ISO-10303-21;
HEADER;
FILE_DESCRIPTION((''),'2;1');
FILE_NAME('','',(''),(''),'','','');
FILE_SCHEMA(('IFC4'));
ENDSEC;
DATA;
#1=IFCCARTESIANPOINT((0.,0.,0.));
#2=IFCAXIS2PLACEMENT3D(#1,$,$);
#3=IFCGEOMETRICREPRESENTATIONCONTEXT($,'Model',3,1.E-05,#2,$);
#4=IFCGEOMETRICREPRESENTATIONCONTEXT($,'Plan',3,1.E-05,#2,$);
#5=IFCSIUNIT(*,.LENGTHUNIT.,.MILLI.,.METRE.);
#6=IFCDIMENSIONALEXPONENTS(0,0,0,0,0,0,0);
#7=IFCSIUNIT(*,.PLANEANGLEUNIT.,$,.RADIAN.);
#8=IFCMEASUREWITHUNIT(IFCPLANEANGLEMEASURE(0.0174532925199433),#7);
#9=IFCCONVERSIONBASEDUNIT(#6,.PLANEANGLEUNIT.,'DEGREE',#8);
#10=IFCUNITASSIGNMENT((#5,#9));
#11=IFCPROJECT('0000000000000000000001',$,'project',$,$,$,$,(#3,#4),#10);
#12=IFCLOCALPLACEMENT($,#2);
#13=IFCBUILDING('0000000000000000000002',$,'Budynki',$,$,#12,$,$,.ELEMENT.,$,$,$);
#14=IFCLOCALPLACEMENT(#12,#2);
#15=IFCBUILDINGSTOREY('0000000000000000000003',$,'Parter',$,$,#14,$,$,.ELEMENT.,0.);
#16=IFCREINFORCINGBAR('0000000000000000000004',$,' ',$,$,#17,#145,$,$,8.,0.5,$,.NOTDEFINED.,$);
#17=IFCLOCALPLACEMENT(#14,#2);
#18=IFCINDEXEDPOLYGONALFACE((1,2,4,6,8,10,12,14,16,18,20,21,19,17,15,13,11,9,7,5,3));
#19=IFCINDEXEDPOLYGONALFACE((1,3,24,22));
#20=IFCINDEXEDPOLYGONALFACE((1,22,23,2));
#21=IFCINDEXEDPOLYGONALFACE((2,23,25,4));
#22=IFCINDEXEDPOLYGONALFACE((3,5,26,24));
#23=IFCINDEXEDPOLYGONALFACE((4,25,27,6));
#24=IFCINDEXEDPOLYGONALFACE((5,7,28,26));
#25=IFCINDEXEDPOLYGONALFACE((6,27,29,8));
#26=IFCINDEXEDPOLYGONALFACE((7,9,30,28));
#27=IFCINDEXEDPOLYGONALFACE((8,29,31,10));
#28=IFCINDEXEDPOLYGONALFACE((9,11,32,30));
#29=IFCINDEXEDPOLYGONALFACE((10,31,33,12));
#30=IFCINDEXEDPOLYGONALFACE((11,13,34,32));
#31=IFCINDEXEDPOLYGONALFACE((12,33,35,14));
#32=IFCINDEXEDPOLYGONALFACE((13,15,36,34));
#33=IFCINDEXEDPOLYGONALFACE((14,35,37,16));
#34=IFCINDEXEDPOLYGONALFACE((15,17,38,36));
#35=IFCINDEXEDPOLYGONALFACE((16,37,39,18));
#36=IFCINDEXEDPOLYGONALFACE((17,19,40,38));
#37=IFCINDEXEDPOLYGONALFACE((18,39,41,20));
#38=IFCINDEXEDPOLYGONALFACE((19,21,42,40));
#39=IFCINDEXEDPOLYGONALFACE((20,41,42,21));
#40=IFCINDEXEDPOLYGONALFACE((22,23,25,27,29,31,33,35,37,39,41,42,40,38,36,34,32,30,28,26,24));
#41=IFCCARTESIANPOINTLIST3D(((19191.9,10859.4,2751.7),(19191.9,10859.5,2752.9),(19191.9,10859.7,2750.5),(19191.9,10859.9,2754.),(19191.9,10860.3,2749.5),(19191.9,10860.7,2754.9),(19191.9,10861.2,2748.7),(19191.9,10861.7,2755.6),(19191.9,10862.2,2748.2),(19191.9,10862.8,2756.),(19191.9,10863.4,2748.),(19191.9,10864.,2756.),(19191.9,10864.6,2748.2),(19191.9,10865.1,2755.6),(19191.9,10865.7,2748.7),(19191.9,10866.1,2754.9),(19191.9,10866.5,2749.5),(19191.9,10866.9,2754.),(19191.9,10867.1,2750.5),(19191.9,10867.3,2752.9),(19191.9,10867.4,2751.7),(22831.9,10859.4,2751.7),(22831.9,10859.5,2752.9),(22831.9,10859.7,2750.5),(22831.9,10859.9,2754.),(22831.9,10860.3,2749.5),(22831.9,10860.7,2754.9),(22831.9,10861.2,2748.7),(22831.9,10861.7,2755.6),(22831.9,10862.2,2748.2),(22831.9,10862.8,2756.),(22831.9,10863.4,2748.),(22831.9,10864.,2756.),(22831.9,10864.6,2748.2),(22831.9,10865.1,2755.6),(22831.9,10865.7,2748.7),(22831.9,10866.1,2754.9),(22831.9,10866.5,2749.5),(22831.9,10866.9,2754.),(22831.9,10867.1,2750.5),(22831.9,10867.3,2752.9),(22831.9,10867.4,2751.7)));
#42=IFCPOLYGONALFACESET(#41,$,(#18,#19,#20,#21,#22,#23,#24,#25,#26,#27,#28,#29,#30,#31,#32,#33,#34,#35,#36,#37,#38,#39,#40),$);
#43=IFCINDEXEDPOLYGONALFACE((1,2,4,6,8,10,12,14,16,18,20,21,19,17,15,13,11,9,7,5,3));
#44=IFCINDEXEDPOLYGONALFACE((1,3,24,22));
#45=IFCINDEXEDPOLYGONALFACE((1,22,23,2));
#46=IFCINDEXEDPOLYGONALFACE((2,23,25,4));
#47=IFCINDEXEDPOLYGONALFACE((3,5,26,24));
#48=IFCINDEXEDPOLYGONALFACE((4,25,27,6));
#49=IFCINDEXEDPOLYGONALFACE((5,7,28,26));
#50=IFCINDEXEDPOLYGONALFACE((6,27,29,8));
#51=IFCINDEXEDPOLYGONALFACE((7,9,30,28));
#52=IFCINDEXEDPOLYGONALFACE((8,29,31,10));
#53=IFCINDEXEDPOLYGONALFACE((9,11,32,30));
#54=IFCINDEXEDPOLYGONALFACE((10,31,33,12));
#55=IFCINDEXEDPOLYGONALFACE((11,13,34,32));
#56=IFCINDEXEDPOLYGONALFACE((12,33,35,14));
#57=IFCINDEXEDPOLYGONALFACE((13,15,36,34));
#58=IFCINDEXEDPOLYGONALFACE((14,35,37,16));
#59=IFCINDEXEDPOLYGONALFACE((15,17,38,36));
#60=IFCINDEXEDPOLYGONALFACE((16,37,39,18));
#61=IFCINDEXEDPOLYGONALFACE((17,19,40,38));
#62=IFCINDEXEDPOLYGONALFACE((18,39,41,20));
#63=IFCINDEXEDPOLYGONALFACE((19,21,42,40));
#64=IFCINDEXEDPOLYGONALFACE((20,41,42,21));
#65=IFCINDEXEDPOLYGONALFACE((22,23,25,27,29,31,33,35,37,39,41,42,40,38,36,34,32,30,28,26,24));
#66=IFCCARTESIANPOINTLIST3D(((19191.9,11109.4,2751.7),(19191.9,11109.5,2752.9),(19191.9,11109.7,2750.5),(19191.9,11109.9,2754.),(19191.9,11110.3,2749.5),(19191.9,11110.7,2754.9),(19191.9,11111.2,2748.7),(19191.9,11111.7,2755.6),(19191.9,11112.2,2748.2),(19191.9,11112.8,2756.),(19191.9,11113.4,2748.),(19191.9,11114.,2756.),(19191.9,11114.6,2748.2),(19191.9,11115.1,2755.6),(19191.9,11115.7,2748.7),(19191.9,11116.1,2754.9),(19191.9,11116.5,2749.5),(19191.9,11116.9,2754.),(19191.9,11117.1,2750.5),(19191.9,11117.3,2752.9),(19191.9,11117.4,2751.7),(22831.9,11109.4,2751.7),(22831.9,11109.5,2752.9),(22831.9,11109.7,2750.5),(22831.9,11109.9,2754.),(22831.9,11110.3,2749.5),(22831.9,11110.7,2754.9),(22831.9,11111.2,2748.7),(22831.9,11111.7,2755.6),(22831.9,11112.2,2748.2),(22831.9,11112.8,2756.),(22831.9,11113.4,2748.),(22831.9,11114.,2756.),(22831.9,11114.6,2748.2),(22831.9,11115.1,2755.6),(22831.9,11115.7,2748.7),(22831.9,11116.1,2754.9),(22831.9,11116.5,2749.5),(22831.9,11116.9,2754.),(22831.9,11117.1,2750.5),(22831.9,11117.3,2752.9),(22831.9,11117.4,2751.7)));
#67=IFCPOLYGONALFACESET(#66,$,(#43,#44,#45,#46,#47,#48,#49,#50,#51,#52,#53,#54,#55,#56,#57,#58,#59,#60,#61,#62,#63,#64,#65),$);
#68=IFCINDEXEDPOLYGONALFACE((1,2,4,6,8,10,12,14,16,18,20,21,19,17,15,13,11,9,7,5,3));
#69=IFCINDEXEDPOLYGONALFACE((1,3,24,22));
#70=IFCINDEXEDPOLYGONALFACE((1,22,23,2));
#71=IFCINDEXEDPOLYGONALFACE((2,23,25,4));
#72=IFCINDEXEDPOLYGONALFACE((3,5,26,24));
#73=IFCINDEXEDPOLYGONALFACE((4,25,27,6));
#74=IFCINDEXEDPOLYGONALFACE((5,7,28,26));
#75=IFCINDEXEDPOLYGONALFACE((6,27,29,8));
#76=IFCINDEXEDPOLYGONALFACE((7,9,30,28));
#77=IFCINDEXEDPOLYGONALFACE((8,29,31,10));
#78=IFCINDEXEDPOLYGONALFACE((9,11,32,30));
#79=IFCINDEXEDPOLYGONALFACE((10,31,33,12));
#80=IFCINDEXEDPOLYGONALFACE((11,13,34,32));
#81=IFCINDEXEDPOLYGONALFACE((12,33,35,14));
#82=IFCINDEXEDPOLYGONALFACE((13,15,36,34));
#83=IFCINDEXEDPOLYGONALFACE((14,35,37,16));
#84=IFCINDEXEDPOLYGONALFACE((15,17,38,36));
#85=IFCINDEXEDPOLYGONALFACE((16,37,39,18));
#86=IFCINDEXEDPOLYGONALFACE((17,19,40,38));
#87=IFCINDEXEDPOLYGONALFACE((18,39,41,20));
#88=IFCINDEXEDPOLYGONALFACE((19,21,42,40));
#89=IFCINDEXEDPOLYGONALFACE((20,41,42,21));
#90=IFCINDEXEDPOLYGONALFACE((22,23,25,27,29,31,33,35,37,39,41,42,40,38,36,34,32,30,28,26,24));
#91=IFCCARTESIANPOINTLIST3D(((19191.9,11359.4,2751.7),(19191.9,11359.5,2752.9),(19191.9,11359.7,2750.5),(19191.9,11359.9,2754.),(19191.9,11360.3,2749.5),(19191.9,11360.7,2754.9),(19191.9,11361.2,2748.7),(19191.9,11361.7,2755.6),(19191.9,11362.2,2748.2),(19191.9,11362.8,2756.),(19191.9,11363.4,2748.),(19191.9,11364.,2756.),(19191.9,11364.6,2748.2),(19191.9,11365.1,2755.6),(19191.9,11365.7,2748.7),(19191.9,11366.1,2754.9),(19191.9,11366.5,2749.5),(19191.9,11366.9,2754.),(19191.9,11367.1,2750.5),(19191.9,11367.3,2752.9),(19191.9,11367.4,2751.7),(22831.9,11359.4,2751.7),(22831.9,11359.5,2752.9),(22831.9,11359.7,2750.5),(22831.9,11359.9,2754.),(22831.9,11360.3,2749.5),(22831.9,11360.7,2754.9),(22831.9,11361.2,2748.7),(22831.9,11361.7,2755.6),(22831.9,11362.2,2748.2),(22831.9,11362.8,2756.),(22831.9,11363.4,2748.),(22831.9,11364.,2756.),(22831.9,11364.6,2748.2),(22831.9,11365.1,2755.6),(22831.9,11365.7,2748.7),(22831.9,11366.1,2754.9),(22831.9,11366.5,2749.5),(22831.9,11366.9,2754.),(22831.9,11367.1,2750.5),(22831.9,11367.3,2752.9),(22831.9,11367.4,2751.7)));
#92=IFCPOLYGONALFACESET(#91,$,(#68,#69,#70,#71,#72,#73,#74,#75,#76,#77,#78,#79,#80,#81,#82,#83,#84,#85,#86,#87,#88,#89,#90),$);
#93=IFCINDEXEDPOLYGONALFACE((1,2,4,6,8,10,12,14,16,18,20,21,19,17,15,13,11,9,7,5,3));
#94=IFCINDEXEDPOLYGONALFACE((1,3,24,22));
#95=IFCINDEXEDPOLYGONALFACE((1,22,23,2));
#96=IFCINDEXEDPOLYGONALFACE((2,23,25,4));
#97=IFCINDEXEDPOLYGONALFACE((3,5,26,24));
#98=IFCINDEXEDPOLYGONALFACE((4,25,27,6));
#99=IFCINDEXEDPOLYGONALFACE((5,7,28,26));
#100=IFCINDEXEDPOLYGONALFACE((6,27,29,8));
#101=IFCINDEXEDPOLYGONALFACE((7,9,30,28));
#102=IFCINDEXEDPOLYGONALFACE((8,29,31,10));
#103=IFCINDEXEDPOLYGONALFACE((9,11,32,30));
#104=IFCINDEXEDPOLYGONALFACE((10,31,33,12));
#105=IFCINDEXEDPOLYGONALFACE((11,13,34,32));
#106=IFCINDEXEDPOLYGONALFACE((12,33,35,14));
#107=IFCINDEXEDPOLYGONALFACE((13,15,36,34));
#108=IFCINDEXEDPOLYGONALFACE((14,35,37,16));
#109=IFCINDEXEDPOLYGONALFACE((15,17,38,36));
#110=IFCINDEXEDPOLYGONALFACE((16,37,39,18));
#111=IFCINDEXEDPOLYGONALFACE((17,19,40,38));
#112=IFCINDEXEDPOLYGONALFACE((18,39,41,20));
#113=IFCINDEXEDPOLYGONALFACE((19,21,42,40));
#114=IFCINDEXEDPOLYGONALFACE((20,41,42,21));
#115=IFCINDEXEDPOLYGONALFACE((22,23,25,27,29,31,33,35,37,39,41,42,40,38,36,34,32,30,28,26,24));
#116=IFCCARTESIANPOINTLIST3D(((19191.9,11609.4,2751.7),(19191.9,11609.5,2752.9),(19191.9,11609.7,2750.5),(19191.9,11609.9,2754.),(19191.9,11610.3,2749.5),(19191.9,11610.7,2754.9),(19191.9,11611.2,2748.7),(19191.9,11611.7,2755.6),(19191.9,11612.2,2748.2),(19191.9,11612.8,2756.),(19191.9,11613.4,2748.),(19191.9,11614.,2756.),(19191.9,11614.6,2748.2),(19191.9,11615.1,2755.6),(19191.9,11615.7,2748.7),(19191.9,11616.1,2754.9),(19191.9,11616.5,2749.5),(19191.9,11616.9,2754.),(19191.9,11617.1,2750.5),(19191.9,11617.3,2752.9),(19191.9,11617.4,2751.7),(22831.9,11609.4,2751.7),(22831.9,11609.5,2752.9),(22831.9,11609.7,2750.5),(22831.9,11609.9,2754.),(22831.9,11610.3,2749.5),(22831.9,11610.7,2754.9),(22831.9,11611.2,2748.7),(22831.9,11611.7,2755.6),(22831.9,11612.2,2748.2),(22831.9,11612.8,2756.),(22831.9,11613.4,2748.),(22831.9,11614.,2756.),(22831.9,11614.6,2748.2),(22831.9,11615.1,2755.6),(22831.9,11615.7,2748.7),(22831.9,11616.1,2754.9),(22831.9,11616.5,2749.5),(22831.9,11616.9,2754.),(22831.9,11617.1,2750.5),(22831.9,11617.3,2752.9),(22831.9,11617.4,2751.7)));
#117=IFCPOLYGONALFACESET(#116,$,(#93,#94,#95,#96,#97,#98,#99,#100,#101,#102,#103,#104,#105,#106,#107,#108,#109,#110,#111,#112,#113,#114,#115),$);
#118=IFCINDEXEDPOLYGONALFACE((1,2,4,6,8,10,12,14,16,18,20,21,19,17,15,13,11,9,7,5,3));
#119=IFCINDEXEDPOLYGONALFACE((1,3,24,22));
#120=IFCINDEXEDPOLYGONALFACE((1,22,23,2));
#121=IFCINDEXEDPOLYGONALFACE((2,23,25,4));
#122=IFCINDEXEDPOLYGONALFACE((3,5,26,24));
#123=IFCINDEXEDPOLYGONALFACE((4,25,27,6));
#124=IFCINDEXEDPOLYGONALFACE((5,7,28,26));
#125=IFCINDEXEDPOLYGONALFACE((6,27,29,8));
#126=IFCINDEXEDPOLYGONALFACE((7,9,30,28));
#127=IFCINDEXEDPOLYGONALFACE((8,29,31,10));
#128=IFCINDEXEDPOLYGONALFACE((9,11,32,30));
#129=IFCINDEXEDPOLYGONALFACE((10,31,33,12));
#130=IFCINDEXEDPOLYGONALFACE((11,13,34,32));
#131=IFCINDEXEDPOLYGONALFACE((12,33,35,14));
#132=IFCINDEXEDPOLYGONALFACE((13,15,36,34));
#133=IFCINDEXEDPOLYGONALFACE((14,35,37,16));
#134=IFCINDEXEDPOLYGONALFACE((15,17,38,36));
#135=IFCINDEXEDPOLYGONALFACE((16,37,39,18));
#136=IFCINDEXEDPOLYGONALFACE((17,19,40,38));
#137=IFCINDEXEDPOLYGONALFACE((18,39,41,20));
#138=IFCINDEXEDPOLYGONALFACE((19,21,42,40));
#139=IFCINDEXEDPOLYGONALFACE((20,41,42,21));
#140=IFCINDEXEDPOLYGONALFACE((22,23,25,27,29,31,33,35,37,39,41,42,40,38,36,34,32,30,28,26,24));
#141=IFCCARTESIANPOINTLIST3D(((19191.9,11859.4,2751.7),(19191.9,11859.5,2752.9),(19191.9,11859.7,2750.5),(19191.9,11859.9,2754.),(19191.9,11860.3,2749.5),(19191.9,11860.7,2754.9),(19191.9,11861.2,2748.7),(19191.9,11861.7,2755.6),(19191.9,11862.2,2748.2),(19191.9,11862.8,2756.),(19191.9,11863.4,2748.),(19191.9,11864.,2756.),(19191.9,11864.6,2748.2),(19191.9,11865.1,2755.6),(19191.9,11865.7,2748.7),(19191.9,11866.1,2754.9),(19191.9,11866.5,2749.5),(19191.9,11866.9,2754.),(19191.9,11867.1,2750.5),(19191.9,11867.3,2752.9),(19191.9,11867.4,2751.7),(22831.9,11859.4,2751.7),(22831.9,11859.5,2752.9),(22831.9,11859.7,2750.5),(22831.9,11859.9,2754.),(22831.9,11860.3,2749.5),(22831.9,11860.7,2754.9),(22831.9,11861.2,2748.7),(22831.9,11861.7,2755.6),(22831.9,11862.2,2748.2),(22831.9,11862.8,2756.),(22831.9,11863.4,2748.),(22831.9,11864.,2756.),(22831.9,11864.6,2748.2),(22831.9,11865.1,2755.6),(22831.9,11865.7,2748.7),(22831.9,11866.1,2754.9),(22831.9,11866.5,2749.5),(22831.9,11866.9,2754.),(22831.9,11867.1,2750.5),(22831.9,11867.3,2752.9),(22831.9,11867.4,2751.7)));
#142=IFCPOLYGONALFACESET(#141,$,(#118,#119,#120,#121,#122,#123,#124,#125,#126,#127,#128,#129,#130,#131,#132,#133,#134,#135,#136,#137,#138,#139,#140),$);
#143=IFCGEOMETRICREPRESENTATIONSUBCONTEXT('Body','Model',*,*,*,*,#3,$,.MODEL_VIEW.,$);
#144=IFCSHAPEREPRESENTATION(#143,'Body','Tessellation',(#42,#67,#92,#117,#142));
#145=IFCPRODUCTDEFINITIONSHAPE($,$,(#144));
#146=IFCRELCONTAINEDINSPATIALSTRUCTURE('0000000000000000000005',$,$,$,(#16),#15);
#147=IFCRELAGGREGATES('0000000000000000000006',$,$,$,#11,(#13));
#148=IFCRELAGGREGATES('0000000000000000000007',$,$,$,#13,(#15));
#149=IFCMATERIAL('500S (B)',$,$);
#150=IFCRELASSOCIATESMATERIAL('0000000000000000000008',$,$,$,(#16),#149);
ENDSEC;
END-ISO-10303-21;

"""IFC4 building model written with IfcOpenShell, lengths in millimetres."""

from ifc_helpers import new_model, entity, si_unit, converted_unit, frame, origin, place, context, subcontext, project, spatial, material, element, save


model = new_model("IFC4")

# Units and contexts
model_context = context("Model", 3, precision=1e-05, world=origin())
plan_context = context("Plan", 3, precision=1e-05, world=origin())
body_context = subcontext(model_context, "Body", "Model", "MODEL_VIEW")
ifc_project = project(units=[si_unit("LENGTHUNIT", "METRE", prefix="MILLI"), converted_unit("PLANEANGLEUNIT", "DEGREE", entity("IfcPlaneAngleMeasure", 0.0174532925199433), si_unit("PLANEANGLEUNIT", "RADIAN"), dimensions=[0, 0, 0, 0, 0, 0, 0])], contexts=[model_context, plan_context])

# Building, storey
building_placement = place(None, origin())
building = spatial("IfcBuilding", under=ifc_project, at=building_placement, Name="Budynki", CompositionType="ELEMENT")
storey_placement = place(building_placement, origin())
storey = spatial("IfcBuildingStorey", under=building, at=storey_placement, Name="Parter", CompositionType="ELEMENT", Elevation=0.0)

# Reinforcing bar
ifc_material_1 = material(Name="500S (B)")
reinforcing_bar_1_placement = place(storey_placement, frame((22831.9, 10863.4, 2752.0)))
element("IfcReinforcingBar", 1, at=reinforcing_bar_1_placement, inside=storey, material=ifc_material_1, Name=" ", CrossSectionArea=0.5, NominalDiameter=8.0, PredefinedType="NOTDEFINED", context=body_context, shape_type="AdvancedSweptSolid", body=[
    entity("IfcSweptDiskSolid", entity("IfcPolyline", [entity("IfcCartesianPoint", [0.0, 0.0, 0.0]), entity("IfcCartesianPoint", [-3640.0, 0.0, 0.0])]), 4.0, None, 0.0, 1.0),
    entity("IfcSweptDiskSolid", entity("IfcPolyline", [entity("IfcCartesianPoint", [0.0, 250.0, 0.0]), entity("IfcCartesianPoint", [-3640.0, 250.0, 0.0])]), 4.0, None, 0.0, 1.0),
    entity("IfcSweptDiskSolid", entity("IfcPolyline", [entity("IfcCartesianPoint", [0.0, 500.0, 0.0]), entity("IfcCartesianPoint", [-3640.0, 500.0, 0.0])]), 4.0, None, 0.0, 1.0),
    entity("IfcSweptDiskSolid", entity("IfcPolyline", [entity("IfcCartesianPoint", [0.0, 750.0, 0.0]), entity("IfcCartesianPoint", [-3640.0, 750.0, 0.0])]), 4.0, None, 0.0, 1.0),
    entity("IfcSweptDiskSolid", entity("IfcPolyline", [entity("IfcCartesianPoint", [0.0, 1000.0, 0.0]), entity("IfcCartesianPoint", [-3640.0, 1000.0, 0.0])]), 4.0, None, 0.0, 1.0),
])

save(model, "model.ifc")
